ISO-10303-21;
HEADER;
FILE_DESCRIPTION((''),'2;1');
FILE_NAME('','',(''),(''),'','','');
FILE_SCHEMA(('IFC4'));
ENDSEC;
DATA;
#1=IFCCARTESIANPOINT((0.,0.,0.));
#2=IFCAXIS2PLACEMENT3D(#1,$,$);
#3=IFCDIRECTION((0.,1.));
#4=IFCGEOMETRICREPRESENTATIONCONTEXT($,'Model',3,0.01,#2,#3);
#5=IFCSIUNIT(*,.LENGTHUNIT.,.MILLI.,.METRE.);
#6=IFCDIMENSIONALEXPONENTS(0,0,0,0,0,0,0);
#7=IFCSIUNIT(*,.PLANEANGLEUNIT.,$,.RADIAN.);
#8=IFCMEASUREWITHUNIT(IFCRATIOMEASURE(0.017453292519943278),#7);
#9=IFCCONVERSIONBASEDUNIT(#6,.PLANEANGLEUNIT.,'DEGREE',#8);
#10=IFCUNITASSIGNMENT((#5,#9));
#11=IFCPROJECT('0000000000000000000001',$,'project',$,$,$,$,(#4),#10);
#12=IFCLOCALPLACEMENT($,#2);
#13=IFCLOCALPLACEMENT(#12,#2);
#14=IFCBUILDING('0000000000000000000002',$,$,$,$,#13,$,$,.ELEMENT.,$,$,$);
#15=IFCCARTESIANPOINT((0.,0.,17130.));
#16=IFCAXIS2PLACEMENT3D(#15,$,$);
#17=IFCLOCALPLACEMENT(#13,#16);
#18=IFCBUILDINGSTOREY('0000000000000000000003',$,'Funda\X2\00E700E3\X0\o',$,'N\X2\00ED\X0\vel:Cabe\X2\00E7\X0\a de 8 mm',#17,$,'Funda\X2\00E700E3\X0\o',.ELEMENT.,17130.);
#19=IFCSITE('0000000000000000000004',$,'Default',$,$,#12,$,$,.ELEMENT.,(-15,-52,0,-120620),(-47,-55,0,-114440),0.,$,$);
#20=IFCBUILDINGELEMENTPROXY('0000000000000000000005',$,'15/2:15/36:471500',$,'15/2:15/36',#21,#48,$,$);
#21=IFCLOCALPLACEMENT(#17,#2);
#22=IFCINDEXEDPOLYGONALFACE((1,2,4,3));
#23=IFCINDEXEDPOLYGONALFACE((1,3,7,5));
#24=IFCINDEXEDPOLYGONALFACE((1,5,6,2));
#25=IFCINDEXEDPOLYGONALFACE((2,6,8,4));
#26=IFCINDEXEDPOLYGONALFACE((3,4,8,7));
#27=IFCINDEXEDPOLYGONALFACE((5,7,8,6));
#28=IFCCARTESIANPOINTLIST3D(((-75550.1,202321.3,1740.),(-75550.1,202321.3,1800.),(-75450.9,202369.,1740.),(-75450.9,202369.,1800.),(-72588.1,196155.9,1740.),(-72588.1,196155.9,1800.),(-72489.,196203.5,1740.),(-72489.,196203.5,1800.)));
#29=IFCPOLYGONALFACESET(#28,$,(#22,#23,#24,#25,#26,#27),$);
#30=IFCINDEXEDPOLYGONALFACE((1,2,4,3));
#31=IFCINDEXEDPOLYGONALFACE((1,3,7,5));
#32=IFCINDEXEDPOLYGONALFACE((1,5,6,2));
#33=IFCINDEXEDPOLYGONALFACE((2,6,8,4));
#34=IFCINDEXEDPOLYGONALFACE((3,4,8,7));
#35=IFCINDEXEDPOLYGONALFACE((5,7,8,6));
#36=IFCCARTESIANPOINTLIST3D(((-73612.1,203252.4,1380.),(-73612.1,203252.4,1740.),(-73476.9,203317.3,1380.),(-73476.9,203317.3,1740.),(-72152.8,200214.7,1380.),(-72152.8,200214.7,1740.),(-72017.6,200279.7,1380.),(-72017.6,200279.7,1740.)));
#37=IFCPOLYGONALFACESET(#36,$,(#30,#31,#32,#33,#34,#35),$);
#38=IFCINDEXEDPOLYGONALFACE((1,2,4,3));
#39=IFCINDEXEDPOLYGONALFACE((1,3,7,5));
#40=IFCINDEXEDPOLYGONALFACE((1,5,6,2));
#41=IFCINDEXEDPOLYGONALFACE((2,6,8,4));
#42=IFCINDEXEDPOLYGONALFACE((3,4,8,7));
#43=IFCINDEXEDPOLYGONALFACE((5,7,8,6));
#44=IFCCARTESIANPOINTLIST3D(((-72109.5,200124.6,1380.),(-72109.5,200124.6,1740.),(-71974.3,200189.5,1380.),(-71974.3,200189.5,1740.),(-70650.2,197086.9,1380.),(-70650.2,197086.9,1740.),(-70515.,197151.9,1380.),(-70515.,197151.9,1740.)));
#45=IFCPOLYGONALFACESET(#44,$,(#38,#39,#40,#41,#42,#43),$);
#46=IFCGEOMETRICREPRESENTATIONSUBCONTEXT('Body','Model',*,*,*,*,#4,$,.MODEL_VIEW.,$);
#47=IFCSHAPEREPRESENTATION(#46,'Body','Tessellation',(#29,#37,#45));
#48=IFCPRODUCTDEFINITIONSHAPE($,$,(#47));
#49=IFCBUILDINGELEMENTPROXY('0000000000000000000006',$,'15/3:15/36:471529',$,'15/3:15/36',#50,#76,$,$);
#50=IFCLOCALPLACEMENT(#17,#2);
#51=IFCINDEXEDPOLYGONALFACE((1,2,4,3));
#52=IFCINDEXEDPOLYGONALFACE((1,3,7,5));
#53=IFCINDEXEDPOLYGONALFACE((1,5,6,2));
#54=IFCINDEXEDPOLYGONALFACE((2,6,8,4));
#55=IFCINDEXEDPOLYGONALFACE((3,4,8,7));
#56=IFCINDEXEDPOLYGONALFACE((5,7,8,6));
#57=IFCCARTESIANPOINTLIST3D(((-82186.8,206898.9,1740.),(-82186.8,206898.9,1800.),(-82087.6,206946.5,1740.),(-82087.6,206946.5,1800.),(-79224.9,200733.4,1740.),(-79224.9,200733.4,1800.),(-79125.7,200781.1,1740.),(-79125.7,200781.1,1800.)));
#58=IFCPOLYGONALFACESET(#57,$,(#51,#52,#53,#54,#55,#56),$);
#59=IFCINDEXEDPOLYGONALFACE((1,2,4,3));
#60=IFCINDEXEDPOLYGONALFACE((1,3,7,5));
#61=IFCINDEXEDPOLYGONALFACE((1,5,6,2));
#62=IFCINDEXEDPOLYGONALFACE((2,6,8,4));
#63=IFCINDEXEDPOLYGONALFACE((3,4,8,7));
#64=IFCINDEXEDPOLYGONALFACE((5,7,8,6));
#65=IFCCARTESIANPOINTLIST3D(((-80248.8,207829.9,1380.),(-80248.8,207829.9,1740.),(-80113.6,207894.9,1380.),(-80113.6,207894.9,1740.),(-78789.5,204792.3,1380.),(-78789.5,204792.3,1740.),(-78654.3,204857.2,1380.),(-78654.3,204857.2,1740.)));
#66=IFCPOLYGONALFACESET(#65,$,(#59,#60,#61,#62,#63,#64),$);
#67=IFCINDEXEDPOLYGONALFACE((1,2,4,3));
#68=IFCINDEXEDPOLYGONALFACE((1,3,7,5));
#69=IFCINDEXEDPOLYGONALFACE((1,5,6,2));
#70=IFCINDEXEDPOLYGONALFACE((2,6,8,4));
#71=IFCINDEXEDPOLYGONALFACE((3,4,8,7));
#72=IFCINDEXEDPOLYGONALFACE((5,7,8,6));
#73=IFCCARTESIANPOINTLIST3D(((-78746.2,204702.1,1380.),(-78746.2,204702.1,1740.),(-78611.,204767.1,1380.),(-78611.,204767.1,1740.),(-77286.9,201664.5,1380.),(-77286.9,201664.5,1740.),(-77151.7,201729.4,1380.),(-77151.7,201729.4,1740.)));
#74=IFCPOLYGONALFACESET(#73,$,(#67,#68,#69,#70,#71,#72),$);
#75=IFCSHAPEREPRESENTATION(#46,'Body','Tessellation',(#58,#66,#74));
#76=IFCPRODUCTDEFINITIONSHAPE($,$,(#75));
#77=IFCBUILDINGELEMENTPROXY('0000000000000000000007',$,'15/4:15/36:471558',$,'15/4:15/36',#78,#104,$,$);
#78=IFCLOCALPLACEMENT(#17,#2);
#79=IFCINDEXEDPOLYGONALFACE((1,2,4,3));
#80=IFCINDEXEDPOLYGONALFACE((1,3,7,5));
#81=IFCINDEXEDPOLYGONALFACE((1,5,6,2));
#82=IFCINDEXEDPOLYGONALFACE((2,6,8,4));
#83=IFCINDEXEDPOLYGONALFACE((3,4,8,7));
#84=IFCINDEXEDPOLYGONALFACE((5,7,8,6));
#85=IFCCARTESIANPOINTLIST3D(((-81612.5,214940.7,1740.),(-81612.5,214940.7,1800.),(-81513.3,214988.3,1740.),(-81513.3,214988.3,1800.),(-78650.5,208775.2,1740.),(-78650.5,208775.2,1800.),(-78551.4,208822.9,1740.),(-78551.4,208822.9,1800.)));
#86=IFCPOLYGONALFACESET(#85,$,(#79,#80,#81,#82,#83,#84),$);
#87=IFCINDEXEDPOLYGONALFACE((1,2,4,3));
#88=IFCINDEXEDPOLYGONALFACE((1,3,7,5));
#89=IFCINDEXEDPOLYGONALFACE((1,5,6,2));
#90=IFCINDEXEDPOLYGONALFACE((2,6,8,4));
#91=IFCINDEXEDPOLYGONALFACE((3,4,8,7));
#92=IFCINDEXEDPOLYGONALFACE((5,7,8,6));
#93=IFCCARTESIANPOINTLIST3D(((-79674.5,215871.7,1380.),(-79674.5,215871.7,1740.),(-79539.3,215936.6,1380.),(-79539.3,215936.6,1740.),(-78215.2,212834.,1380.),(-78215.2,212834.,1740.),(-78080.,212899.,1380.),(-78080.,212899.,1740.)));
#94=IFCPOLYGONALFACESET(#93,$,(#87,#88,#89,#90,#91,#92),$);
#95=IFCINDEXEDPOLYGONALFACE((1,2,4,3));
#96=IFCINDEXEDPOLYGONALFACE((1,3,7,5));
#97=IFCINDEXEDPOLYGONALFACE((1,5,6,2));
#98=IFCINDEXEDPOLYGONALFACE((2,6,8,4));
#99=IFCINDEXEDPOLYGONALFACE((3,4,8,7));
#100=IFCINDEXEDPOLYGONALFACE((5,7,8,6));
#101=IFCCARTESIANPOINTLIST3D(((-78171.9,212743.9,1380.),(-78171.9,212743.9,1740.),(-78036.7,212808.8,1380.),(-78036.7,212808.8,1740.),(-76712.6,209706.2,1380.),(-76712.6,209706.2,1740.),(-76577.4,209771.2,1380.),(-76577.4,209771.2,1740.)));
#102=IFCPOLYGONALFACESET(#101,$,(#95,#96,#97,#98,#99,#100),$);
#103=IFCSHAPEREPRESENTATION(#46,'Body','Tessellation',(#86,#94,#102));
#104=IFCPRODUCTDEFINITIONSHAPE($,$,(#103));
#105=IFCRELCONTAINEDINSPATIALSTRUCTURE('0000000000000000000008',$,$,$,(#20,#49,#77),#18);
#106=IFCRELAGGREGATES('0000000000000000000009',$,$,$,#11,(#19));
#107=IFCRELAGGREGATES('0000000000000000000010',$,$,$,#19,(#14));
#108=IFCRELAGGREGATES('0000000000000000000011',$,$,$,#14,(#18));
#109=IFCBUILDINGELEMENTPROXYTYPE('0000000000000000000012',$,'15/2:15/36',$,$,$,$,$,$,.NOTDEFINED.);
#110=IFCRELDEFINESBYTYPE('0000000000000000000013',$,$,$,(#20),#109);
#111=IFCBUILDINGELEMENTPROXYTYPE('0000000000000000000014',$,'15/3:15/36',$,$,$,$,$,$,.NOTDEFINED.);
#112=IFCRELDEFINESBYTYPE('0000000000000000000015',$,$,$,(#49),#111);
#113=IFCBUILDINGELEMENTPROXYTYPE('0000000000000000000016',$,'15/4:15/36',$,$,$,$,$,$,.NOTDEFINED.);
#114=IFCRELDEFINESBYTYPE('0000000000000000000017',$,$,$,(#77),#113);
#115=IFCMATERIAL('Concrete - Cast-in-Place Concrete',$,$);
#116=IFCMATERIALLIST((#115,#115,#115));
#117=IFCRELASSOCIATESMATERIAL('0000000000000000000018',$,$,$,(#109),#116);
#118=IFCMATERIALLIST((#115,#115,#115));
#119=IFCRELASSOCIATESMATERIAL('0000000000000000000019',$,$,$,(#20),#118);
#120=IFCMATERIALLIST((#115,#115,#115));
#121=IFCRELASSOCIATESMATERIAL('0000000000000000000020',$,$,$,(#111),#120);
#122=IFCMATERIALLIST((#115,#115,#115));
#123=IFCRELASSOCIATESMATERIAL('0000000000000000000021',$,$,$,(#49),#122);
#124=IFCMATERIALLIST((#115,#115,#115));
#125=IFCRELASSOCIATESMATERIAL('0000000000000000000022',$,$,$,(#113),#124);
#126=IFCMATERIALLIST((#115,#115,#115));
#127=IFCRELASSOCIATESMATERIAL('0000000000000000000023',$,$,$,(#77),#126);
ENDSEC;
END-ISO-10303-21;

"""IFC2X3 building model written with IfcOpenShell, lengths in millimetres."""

from ifc_helpers import new_model, entity, si_unit, converted_unit, direction, frame, frame_2d, origin, place, context, subcontext, project, spatial, rectangle, extrude, source, transform, mapped, material, material_list, type_object, type_shapes, element, save


model = new_model("IFC2X3")

# Units and contexts
model_context = context("Model", 3, precision=0.01, world=origin(), true_north=direction((0.0, 1.0)))
body_context = subcontext(model_context, "Body", "Model", "MODEL_VIEW")
ifc_project = project(units=[si_unit("LENGTHUNIT", "METRE", prefix="MILLI"), converted_unit("PLANEANGLEUNIT", "DEGREE", entity("IfcRatioMeasure", 0.017453292519943278), si_unit("PLANEANGLEUNIT", "RADIAN"), dimensions=[0, 0, 0, 0, 0, 0, 0])], contexts=[model_context])

# Site, building, storey
site_placement = place(None, origin())
site = spatial("IfcSite", under=ifc_project, at=site_placement, Name="Default", CompositionType="ELEMENT", RefLatitude=(-15, -52, 0, -120620), RefLongitude=(-47, -55, 0, -114440), RefElevation=0.0)
building_placement = place(site_placement, origin())
building = spatial("IfcBuilding", under=site, at=building_placement, CompositionType="ELEMENT")
storey_placement = place(building_placement, frame((0.0, 0.0, 17130.0)))
storey = spatial("IfcBuildingStorey", under=building, at=storey_placement, Name="Fundação", ObjectType="Nível:Cabeça de 8 mm", LongName="Fundação", CompositionType="ELEMENT", Elevation=17130.0)

# Building element proxies
ifc_material_1 = material(Name="Concrete - Cast-in-Place Concrete")
ifc_material_list_1 = material_list([ifc_material_1, ifc_material_1, ifc_material_1])
ifc_material_list_2 = material_list([ifc_material_1, ifc_material_1, ifc_material_1])
building_element_proxy_type_1 = type_object("IfcBuildingElementProxyType", Name="15/2:15/36", PredefinedType="NOTDEFINED", material=ifc_material_list_2)
shared_shape_1 = source(origin(), body_context, "Body", "SweptSolid", [
    extrude(rectangle(XDim=110.0, YDim=6840.0, at=frame_2d((0.0, 0.0), x_axis=(1.0, 0.0))), frame((1530.5, 3106.5, 360.0), z_axis=(0.0, 0.0, 1.0), x_axis=(0.90138, 0.43303, 0.0)), (0.0, 0.0, 1.0), 60.0),
    extrude(rectangle(XDim=3370.0, YDim=150.0, at=frame_2d((0.0, 0.0), x_axis=(1.0, 0.0))), frame((2735.2, 5610.1, 0.0), z_axis=(0.0, 0.0, 1.0), x_axis=(0.43303, -0.90138, 0.0)), (0.0, 0.0, 1.0), 360.0),
    extrude(rectangle(XDim=3370.0, YDim=150.0, at=frame_2d((0.0, 0.0), x_axis=(1.0, 0.0))), frame((4237.8, 2482.3, 0.0), z_axis=(0.0, 0.0, 1.0), x_axis=(0.43303, -0.90138, 0.0)), (0.0, 0.0, 1.0), 360.0),
])
type_shapes(building_element_proxy_type_1, [shared_shape_1])
proxy_1_placement = place(storey_placement, frame((-75550.1, 196155.9, 1380.0)))
element("IfcBuildingElementProxy", 1, at=proxy_1_placement, inside=storey, type_object=building_element_proxy_type_1, material=ifc_material_list_1, Name="15/2:15/36:471500", ObjectType="15/2:15/36", context=body_context, shape_type="MappedRepresentation", body=[
    mapped(shared_shape_1, transform((0.0, 0.0, 0.0), scale=1.0)),
])
ifc_material_list_3 = material_list([ifc_material_1, ifc_material_1, ifc_material_1])
ifc_material_list_4 = material_list([ifc_material_1, ifc_material_1, ifc_material_1])
building_element_proxy_type_2 = type_object("IfcBuildingElementProxyType", Name="15/3:15/36", PredefinedType="NOTDEFINED", material=ifc_material_list_4)
shared_shape_2 = source(origin(), body_context, "Body", "SweptSolid", [
    extrude(rectangle(XDim=110.0, YDim=6840.0, at=frame_2d((0.0, 0.0), x_axis=(1.0, 0.0))), frame((1530.5, 3106.5, 360.0), z_axis=(0.0, 0.0, 1.0), x_axis=(0.90138, 0.43303, 0.0)), (0.0, 0.0, 1.0), 60.0),
    extrude(rectangle(XDim=3370.0, YDim=150.0, at=frame_2d((0.0, 0.0), x_axis=(1.0, 0.0))), frame((2735.2, 5610.1, 0.0), z_axis=(0.0, 0.0, 1.0), x_axis=(0.43303, -0.90138, 0.0)), (0.0, 0.0, 1.0), 360.0),
    extrude(rectangle(XDim=3370.0, YDim=150.0, at=frame_2d((0.0, 0.0), x_axis=(1.0, 0.0))), frame((4237.8, 2482.3, 0.0), z_axis=(0.0, 0.0, 1.0), x_axis=(0.43303, -0.90138, 0.0)), (0.0, 0.0, 1.0), 360.0),
])
type_shapes(building_element_proxy_type_2, [shared_shape_2])
proxy_2_placement = place(storey_placement, frame((-82186.8, 200733.4, 1380.0)))
element("IfcBuildingElementProxy", 2, at=proxy_2_placement, inside=storey, type_object=building_element_proxy_type_2, material=ifc_material_list_3, Name="15/3:15/36:471529", ObjectType="15/3:15/36", context=body_context, shape_type="MappedRepresentation", body=[
    mapped(shared_shape_2, transform((0.0, 0.0, 0.0), scale=1.0)),
])
ifc_material_list_5 = material_list([ifc_material_1, ifc_material_1, ifc_material_1])
ifc_material_list_6 = material_list([ifc_material_1, ifc_material_1, ifc_material_1])
building_element_proxy_type_3 = type_object("IfcBuildingElementProxyType", Name="15/4:15/36", PredefinedType="NOTDEFINED", material=ifc_material_list_6)
shared_shape_3 = source(origin(), body_context, "Body", "SweptSolid", [
    extrude(rectangle(XDim=110.0, YDim=6840.0, at=frame_2d((0.0, 0.0), x_axis=(1.0, 0.0))), frame((1530.5, 3106.5, 360.0), z_axis=(0.0, 0.0, 1.0), x_axis=(0.90138, 0.43303, 0.0)), (0.0, 0.0, 1.0), 60.0),
    extrude(rectangle(XDim=3370.0, YDim=150.0, at=frame_2d((0.0, 0.0), x_axis=(1.0, 0.0))), frame((2735.2, 5610.1, 0.0), z_axis=(0.0, 0.0, 1.0), x_axis=(0.43303, -0.90138, 0.0)), (0.0, 0.0, 1.0), 360.0),
    extrude(rectangle(XDim=3370.0, YDim=150.0, at=frame_2d((0.0, 0.0), x_axis=(1.0, 0.0))), frame((4237.8, 2482.3, 0.0), z_axis=(0.0, 0.0, 1.0), x_axis=(0.43303, -0.90138, 0.0)), (0.0, 0.0, 1.0), 360.0),
])
type_shapes(building_element_proxy_type_3, [shared_shape_3])
proxy_3_placement = place(storey_placement, frame((-81612.5, 208775.2, 1380.0)))
element("IfcBuildingElementProxy", 3, at=proxy_3_placement, inside=storey, type_object=building_element_proxy_type_3, material=ifc_material_list_5, Name="15/4:15/36:471558", ObjectType="15/4:15/36", context=body_context, shape_type="MappedRepresentation", body=[
    mapped(shared_shape_3, transform((0.0, 0.0, 0.0), scale=1.0)),
])

save(model, "model.ifc")
